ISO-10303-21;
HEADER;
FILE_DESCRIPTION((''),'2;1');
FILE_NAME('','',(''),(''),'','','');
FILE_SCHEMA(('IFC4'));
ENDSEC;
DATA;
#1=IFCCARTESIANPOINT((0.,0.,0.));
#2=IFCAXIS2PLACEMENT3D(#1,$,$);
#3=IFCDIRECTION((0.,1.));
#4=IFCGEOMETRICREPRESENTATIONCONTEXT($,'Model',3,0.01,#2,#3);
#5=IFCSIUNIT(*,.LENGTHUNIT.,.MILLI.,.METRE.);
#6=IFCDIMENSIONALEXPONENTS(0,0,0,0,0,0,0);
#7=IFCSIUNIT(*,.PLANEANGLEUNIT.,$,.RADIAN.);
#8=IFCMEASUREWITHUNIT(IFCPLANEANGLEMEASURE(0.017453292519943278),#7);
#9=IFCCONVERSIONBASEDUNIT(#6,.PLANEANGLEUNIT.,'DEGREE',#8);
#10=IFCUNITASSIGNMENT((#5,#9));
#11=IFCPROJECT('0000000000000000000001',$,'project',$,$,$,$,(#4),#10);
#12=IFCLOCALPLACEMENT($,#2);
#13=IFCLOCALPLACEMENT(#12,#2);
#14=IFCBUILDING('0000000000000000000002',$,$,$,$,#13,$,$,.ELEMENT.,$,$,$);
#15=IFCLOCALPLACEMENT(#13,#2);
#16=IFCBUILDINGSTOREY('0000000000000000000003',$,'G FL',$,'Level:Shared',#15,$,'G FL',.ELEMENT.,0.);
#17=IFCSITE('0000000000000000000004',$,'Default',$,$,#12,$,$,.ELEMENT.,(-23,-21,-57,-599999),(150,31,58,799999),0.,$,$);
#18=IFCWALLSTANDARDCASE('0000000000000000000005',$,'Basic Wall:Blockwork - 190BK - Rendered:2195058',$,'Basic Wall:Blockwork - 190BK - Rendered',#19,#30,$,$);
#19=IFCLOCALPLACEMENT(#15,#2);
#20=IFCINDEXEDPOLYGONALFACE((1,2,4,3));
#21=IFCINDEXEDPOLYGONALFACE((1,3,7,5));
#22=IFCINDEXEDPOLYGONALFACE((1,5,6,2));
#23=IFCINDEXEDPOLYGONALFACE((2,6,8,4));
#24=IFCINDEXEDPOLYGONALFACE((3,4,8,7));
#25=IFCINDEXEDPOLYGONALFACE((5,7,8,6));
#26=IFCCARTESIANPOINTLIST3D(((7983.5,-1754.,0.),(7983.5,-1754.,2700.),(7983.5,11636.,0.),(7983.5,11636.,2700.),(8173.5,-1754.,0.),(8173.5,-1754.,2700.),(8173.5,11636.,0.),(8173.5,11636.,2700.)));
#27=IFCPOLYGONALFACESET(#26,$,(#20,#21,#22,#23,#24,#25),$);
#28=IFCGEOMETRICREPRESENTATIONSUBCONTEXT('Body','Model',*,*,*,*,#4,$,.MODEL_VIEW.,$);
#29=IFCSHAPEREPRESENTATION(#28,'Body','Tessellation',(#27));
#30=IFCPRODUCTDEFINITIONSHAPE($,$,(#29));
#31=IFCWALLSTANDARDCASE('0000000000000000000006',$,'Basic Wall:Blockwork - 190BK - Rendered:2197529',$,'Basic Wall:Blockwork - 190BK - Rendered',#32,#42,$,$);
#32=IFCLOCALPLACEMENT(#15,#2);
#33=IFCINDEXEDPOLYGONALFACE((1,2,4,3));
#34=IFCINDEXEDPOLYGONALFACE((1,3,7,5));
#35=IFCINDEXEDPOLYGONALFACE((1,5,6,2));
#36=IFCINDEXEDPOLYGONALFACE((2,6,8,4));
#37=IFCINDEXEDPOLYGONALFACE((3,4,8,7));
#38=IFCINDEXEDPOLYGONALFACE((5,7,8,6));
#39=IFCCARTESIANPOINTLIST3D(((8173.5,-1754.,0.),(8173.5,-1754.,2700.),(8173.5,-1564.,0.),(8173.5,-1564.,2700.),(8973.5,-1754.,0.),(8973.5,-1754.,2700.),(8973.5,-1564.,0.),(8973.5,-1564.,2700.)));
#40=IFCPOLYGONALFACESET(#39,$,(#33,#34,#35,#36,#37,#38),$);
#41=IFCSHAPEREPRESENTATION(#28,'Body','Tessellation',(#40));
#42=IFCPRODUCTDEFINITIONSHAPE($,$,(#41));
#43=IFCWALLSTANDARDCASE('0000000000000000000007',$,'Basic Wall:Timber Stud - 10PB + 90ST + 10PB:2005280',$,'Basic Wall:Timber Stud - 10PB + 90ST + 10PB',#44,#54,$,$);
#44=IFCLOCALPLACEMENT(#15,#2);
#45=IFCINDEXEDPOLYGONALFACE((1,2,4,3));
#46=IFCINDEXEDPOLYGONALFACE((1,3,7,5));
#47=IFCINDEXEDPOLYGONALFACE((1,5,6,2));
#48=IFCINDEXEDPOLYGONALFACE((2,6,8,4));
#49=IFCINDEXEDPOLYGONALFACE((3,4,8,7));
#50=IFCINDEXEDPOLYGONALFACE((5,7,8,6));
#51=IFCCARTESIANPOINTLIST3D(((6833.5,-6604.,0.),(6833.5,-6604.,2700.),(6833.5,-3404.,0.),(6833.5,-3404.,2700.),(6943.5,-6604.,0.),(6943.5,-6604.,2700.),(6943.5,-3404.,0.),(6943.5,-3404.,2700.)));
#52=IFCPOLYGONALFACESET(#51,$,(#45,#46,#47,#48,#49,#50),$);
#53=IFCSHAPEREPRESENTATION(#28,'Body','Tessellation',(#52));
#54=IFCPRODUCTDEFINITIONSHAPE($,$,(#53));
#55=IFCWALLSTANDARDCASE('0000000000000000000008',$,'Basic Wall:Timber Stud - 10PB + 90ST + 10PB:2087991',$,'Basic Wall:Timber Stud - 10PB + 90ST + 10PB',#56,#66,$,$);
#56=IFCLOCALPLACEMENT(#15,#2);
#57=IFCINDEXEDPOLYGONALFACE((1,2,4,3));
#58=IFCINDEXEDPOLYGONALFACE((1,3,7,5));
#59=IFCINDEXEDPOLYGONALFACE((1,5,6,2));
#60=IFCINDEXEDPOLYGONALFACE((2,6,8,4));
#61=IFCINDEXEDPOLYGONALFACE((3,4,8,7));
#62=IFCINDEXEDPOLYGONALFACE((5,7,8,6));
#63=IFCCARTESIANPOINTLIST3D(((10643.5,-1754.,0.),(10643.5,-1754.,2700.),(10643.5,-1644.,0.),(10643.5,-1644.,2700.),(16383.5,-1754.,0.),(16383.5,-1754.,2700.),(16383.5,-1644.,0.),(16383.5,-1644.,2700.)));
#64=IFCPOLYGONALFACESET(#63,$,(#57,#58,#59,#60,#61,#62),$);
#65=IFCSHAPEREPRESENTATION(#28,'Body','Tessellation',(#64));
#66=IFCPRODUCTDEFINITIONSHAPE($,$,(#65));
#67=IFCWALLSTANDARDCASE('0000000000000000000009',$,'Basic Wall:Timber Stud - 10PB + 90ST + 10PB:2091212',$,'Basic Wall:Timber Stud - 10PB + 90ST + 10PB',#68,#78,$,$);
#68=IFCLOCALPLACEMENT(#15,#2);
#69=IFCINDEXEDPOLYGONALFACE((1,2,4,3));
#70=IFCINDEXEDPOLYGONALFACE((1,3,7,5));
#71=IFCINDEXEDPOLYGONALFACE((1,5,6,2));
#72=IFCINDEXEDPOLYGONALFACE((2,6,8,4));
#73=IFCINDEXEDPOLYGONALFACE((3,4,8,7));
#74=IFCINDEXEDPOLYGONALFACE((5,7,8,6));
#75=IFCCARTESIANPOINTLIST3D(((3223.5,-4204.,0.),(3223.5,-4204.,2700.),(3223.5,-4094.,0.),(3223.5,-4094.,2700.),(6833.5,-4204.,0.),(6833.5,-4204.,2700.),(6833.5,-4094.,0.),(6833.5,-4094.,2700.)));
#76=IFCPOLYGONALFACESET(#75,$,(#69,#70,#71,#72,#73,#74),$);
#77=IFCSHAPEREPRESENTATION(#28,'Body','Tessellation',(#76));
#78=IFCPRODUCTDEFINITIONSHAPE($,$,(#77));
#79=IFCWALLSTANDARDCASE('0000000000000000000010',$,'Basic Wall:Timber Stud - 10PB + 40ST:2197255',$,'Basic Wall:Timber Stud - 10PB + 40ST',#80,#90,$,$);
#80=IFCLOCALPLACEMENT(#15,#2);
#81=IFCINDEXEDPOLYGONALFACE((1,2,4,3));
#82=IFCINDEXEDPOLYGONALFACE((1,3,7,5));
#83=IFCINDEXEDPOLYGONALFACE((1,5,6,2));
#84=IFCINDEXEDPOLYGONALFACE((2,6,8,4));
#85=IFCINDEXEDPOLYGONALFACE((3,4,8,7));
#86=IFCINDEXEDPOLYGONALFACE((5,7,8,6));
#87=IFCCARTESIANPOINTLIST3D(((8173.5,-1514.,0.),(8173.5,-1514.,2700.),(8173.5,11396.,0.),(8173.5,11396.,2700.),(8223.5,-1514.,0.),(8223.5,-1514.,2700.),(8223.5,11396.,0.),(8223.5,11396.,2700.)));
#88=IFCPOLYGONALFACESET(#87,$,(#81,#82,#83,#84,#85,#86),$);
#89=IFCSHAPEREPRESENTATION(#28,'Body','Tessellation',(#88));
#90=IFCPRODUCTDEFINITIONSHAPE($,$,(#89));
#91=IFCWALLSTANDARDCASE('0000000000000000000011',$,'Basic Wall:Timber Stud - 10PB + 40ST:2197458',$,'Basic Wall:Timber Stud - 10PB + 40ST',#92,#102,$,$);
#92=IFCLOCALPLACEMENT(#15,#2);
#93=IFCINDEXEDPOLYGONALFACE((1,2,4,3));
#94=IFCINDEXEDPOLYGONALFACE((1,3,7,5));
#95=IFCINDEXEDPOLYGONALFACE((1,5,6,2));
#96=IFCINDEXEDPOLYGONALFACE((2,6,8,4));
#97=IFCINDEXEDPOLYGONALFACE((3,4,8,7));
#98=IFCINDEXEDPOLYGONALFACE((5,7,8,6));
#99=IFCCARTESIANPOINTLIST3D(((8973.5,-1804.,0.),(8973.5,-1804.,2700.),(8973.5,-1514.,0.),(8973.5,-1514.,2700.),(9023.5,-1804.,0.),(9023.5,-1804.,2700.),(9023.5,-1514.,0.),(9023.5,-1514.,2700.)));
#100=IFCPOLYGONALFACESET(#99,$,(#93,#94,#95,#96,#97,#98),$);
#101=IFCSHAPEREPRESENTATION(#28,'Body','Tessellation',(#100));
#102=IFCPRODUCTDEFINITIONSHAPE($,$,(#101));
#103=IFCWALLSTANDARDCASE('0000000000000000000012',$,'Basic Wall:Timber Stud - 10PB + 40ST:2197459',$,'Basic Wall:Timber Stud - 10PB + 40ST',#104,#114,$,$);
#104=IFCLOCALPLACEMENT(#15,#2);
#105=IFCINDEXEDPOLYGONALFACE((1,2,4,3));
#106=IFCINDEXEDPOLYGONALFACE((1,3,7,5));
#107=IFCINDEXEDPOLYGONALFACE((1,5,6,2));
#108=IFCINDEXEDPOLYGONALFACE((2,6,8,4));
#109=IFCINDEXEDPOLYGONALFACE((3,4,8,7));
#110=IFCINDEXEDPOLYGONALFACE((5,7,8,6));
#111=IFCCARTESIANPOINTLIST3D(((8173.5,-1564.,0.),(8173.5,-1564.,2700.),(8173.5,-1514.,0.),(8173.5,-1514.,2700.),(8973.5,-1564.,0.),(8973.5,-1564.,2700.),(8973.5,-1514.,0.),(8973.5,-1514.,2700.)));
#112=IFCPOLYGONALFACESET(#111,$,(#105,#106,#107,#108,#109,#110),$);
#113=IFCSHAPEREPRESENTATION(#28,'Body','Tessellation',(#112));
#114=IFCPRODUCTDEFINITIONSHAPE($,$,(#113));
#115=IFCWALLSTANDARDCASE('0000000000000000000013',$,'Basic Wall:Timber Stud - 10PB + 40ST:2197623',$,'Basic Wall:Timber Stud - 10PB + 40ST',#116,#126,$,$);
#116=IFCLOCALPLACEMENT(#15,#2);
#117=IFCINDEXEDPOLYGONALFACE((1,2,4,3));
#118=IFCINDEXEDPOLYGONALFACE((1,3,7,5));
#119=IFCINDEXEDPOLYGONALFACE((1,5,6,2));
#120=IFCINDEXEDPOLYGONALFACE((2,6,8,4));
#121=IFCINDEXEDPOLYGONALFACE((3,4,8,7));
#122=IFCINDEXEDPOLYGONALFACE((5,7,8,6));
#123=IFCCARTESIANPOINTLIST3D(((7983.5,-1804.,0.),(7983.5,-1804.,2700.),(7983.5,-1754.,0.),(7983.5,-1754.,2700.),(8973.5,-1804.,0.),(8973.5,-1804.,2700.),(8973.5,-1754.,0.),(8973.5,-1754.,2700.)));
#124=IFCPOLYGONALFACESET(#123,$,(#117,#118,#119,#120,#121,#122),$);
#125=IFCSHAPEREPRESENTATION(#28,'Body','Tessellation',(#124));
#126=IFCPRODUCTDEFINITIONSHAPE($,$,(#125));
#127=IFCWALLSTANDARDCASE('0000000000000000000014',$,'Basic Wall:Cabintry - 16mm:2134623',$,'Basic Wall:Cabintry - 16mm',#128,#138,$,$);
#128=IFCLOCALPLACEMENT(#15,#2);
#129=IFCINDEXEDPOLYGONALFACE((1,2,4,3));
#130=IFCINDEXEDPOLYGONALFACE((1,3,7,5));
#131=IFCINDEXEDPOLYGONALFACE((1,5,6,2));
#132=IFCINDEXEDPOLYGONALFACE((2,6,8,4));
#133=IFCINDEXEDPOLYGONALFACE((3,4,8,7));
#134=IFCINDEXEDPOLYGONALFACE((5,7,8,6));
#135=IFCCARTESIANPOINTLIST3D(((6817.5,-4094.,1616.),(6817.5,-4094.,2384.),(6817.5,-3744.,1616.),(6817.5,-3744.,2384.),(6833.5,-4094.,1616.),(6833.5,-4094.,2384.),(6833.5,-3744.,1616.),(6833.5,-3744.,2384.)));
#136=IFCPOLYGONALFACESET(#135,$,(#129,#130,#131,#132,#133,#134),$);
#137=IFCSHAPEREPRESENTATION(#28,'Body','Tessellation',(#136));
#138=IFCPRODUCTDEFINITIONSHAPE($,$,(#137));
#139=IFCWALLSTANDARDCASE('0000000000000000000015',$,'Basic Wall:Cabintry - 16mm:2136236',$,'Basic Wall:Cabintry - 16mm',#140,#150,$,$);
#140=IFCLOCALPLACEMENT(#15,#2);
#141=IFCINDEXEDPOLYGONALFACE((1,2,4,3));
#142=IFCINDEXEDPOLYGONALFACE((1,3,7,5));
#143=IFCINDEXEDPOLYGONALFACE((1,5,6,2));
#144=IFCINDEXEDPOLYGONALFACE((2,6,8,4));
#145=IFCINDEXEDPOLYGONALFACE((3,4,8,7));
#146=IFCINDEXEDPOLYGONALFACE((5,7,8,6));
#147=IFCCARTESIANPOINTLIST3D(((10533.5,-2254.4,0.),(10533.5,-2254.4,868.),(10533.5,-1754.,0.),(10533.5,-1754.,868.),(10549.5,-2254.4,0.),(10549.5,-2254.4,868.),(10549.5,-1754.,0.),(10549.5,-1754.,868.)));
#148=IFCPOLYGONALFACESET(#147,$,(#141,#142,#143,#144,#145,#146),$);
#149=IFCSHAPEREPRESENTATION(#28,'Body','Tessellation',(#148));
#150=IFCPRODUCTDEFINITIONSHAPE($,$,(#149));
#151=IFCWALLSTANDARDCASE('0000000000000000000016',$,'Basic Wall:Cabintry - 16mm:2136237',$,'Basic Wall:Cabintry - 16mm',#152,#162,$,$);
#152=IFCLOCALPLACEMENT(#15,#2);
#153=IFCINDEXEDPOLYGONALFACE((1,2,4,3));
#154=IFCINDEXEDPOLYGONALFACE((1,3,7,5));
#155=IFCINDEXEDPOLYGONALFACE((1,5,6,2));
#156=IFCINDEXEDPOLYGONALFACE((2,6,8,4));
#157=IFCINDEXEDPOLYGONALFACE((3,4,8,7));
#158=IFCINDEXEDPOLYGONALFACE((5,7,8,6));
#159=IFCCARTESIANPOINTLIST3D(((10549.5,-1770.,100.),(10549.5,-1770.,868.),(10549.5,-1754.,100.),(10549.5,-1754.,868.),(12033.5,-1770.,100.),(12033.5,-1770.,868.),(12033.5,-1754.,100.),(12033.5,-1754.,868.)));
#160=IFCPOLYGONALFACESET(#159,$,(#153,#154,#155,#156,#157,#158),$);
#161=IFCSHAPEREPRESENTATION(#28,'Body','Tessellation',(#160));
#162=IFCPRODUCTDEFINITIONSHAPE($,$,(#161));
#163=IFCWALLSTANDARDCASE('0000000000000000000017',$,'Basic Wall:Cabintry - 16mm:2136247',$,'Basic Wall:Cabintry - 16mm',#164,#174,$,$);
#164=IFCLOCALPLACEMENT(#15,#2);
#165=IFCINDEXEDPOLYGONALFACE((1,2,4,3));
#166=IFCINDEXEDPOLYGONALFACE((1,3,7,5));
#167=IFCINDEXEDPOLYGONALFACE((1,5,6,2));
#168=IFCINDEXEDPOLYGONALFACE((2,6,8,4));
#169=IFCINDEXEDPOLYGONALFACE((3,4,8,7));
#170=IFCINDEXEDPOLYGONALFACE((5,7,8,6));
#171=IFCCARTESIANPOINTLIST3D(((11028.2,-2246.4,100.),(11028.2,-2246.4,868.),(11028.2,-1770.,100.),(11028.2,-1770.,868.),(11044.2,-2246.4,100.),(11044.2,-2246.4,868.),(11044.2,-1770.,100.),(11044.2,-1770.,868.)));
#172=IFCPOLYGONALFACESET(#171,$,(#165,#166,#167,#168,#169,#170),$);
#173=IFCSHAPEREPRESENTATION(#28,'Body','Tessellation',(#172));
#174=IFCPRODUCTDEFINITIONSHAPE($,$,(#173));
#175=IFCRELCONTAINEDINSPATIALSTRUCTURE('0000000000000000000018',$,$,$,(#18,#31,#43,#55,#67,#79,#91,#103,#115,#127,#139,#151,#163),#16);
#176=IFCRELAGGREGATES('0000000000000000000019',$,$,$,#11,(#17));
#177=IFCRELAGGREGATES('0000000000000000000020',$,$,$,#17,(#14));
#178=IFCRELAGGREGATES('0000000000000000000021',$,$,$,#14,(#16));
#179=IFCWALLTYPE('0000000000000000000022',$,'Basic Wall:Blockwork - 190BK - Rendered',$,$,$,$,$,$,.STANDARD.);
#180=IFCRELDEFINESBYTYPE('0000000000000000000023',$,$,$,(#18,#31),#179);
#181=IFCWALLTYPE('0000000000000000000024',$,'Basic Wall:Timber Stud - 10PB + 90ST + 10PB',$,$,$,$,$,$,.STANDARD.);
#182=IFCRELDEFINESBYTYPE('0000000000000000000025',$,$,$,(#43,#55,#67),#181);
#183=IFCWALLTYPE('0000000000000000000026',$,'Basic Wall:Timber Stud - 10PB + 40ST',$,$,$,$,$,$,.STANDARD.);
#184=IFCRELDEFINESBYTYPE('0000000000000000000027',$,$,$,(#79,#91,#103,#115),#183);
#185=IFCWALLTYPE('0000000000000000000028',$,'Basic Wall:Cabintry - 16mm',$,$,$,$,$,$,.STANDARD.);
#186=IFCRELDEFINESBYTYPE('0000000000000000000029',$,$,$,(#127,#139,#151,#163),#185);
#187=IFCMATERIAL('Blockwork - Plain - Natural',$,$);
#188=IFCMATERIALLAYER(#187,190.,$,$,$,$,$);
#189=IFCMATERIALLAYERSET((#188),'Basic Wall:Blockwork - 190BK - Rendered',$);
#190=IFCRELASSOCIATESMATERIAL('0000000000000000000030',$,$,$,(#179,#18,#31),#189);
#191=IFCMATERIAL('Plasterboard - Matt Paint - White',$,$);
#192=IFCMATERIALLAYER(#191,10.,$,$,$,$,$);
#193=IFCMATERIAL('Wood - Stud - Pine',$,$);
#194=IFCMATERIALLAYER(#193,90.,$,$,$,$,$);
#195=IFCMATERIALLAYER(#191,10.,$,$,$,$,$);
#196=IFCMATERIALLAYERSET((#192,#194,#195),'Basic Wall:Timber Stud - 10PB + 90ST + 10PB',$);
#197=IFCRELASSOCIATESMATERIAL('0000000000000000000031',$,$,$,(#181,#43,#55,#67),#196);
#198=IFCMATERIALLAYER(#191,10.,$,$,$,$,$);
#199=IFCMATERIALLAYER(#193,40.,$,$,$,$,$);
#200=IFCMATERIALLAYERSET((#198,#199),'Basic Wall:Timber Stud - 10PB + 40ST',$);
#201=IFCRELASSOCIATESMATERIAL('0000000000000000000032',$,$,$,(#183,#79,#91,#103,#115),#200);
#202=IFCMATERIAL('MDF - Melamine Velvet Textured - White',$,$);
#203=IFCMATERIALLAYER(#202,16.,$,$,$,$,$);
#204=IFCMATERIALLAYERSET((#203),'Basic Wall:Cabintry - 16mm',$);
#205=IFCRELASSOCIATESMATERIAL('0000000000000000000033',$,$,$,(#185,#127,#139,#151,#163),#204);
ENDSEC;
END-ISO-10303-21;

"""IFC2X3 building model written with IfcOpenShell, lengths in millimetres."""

from ifc_helpers import new_model, entity, si_unit, converted_unit, direction, frame, frame_2d, origin, place, context, subcontext, project, spatial, rectangle, extrude, material, layer, layer_set, layer_usage, type_object, element, save


model = new_model("IFC2X3")

# Units and contexts
model_context = context("Model", 3, precision=0.01, world=origin(), true_north=direction((0.0, 1.0)))
body_context = subcontext(model_context, "Body", "Model", "MODEL_VIEW")
ifc_project = project(units=[si_unit("LENGTHUNIT", "METRE", prefix="MILLI"), converted_unit("PLANEANGLEUNIT", "DEGREE", entity("IfcPlaneAngleMeasure", 0.017453292519943278), si_unit("PLANEANGLEUNIT", "RADIAN"), dimensions=[0, 0, 0, 0, 0, 0, 0])], contexts=[model_context])

# Site, building, storey
site_placement = place(None, origin())
site = spatial("IfcSite", under=ifc_project, at=site_placement, Name="Default", CompositionType="ELEMENT", RefLatitude=(-23, -21, -57, -599999), RefLongitude=(150, 31, 58, 799999), RefElevation=0.0)
building_placement = place(site_placement, origin())
building = spatial("IfcBuilding", under=site, at=building_placement, CompositionType="ELEMENT")
storey_placement = place(building_placement, origin())
storey = spatial("IfcBuildingStorey", under=building, at=storey_placement, Name="G FL", ObjectType="Level:Shared", LongName="G FL", CompositionType="ELEMENT", Elevation=0.0)

# Walls
ifc_material_1 = material(Name="Blockwork - Plain - Natural")
ifc_layer_1 = layer(ifc_material_1, 190.0)
ifc_layer_set_1 = layer_set([ifc_layer_1], Name="Basic Wall:Blockwork - 190BK - Rendered")
ifc_layer_usage_1 = layer_usage(ifc_layer_set_1, "AXIS2", "NEGATIVE", 95.0)
wall_type_1 = type_object("IfcWallType", Name="Basic Wall:Blockwork - 190BK - Rendered", PredefinedType="STANDARD", material=ifc_layer_set_1)
wall_1_placement = place(storey_placement, frame((8078.5, -1754.0, 0.0), z_axis=(0.0, 0.0, 1.0), x_axis=(0.0, 1.0, 0.0)))
element("IfcWallStandardCase", 1, at=wall_1_placement, inside=storey, type_object=wall_type_1, material=ifc_layer_usage_1, Name="Basic Wall:Blockwork - 190BK - Rendered:2195058", ObjectType="Basic Wall:Blockwork - 190BK - Rendered", context=body_context, shape_type="SweptSolid", body=[
    extrude(rectangle(XDim=13390.0, YDim=190.0, at=frame_2d((6695.0, 0.0), x_axis=(-1.0, 0.0))), origin(), (0.0, 0.0, 1.0), 2700.0),
])
ifc_layer_usage_2 = layer_usage(ifc_layer_set_1, "AXIS2", "POSITIVE", -95.0)
wall_2_placement = place(storey_placement, frame((8973.5, -1659.0, 0.0), z_axis=(0.0, 0.0, 1.0), x_axis=(-1.0, 0.0, 0.0)))
element("IfcWallStandardCase", 2, at=wall_2_placement, inside=storey, type_object=wall_type_1, material=ifc_layer_usage_2, Name="Basic Wall:Blockwork - 190BK - Rendered:2197529", ObjectType="Basic Wall:Blockwork - 190BK - Rendered", context=body_context, shape_type="SweptSolid", body=[
    extrude(rectangle(XDim=800.0, YDim=190.0, at=frame_2d((400.0, 0.0), x_axis=(-1.0, 0.0))), origin(), (0.0, 0.0, 1.0), 2700.0),
])
ifc_material_2 = material(Name="Plasterboard - Matt Paint - White")
ifc_layer_2 = layer(ifc_material_2, 10.0)
ifc_material_3 = material(Name="Wood - Stud - Pine")
ifc_layer_3 = layer(ifc_material_3, 90.0)
ifc_layer_4 = layer(ifc_material_2, 10.0)
ifc_layer_set_2 = layer_set([ifc_layer_2, ifc_layer_3, ifc_layer_4], Name="Basic Wall:Timber Stud - 10PB + 90ST + 10PB")
ifc_layer_usage_3 = layer_usage(ifc_layer_set_2, "AXIS2", "NEGATIVE", 55.0)
wall_type_2 = type_object("IfcWallType", Name="Basic Wall:Timber Stud - 10PB + 90ST + 10PB", PredefinedType="STANDARD", material=ifc_layer_set_2)
wall_3_placement = place(storey_placement, frame((6888.5, -3404.0, 0.0), z_axis=(0.0, 0.0, 1.0), x_axis=(0.0, -1.0, 0.0)))
element("IfcWallStandardCase", 3, at=wall_3_placement, inside=storey, type_object=wall_type_2, material=ifc_layer_usage_3, Name="Basic Wall:Timber Stud - 10PB + 90ST + 10PB:2005280", ObjectType="Basic Wall:Timber Stud - 10PB + 90ST + 10PB", context=body_context, shape_type="SweptSolid", body=[
    extrude(rectangle(XDim=3200.0, YDim=110.0, at=frame_2d((1600.0, 0.0), x_axis=(-1.0, 0.0))), origin(), (0.0, 0.0, 1.0), 2700.0),
])
ifc_layer_usage_4 = layer_usage(ifc_layer_set_2, "AXIS2", "NEGATIVE", 55.0)
wall_4_placement = place(storey_placement, frame((10643.5, -1699.0, 0.0)))
element("IfcWallStandardCase", 4, at=wall_4_placement, inside=storey, type_object=wall_type_2, material=ifc_layer_usage_4, Name="Basic Wall:Timber Stud - 10PB + 90ST + 10PB:2087991", ObjectType="Basic Wall:Timber Stud - 10PB + 90ST + 10PB", context=body_context, shape_type="SweptSolid", body=[
    extrude(rectangle(XDim=5740.0, YDim=110.0, at=frame_2d((2870.0, 0.0), x_axis=(-1.0, 0.0))), origin(), (0.0, 0.0, 1.0), 2700.0),
])
ifc_layer_usage_5 = layer_usage(ifc_layer_set_2, "AXIS2", "POSITIVE", -55.0)
wall_5_placement = place(storey_placement, frame((6833.5, -4149.0, 0.0), z_axis=(0.0, 0.0, 1.0), x_axis=(-1.0, 0.0, 0.0)))
element("IfcWallStandardCase", 5, at=wall_5_placement, inside=storey, type_object=wall_type_2, material=ifc_layer_usage_5, Name="Basic Wall:Timber Stud - 10PB + 90ST + 10PB:2091212", ObjectType="Basic Wall:Timber Stud - 10PB + 90ST + 10PB", context=body_context, shape_type="SweptSolid", body=[
    extrude(rectangle(XDim=3610.0, YDim=110.0, at=frame_2d((1805.0, 0.0), x_axis=(-1.0, 0.0))), origin(), (0.0, 0.0, 1.0), 2700.0),
])
ifc_layer_5 = layer(ifc_material_2, 10.0)
ifc_layer_6 = layer(ifc_material_3, 40.0)
ifc_layer_set_3 = layer_set([ifc_layer_5, ifc_layer_6], Name="Basic Wall:Timber Stud - 10PB + 40ST")
ifc_layer_usage_6 = layer_usage(ifc_layer_set_3, "AXIS2", "POSITIVE", -25.0)
wall_type_3 = type_object("IfcWallType", Name="Basic Wall:Timber Stud - 10PB + 40ST", PredefinedType="STANDARD", material=ifc_layer_set_3)
wall_6_placement = place(storey_placement, frame((8198.5, -1514.0, 0.0), z_axis=(0.0, 0.0, 1.0), x_axis=(0.0, 1.0, 0.0)))
element("IfcWallStandardCase", 6, at=wall_6_placement, inside=storey, type_object=wall_type_3, material=ifc_layer_usage_6, Name="Basic Wall:Timber Stud - 10PB + 40ST:2197255", ObjectType="Basic Wall:Timber Stud - 10PB + 40ST", context=body_context, shape_type="SweptSolid", body=[
    extrude(rectangle(XDim=12910.0, YDim=50.0, at=frame_2d((6455.0, 0.0), x_axis=(-1.0, 0.0))), origin(), (0.0, 0.0, 1.0), 2700.0),
])
ifc_layer_usage_7 = layer_usage(ifc_layer_set_3, "AXIS2", "POSITIVE", -25.0)
wall_7_placement = place(storey_placement, frame((8998.5, -1804.0, 0.0), z_axis=(0.0, 0.0, 1.0), x_axis=(0.0, 1.0, 0.0)))
element("IfcWallStandardCase", 7, at=wall_7_placement, inside=storey, type_object=wall_type_3, material=ifc_layer_usage_7, Name="Basic Wall:Timber Stud - 10PB + 40ST:2197458", ObjectType="Basic Wall:Timber Stud - 10PB + 40ST", context=body_context, shape_type="SweptSolid", body=[
    extrude(rectangle(XDim=290.0, YDim=50.0, at=frame_2d((145.0, 0.0), x_axis=(-1.0, 0.0))), origin(), (0.0, 0.0, 1.0), 2700.0),
])
ifc_layer_usage_8 = layer_usage(ifc_layer_set_3, "AXIS2", "POSITIVE", -25.0)
wall_8_placement = place(storey_placement, frame((8973.5, -1539.0, 0.0), z_axis=(0.0, 0.0, 1.0), x_axis=(-1.0, 0.0, 0.0)))
element("IfcWallStandardCase", 8, at=wall_8_placement, inside=storey, type_object=wall_type_3, material=ifc_layer_usage_8, Name="Basic Wall:Timber Stud - 10PB + 40ST:2197459", ObjectType="Basic Wall:Timber Stud - 10PB + 40ST", context=body_context, shape_type="SweptSolid", body=[
    extrude(rectangle(XDim=800.0, YDim=50.0, at=frame_2d((400.0, 0.0), x_axis=(-1.0, 0.0))), origin(), (0.0, 0.0, 1.0), 2700.0),
])
ifc_layer_usage_9 = layer_usage(ifc_layer_set_3, "AXIS2", "NEGATIVE", 25.0)
wall_9_placement = place(storey_placement, frame((8973.5, -1779.0, 0.0), z_axis=(0.0, 0.0, 1.0), x_axis=(-1.0, 0.0, 0.0)))
element("IfcWallStandardCase", 9, at=wall_9_placement, inside=storey, type_object=wall_type_3, material=ifc_layer_usage_9, Name="Basic Wall:Timber Stud - 10PB + 40ST:2197623", ObjectType="Basic Wall:Timber Stud - 10PB + 40ST", context=body_context, shape_type="SweptSolid", body=[
    extrude(rectangle(XDim=990.0, YDim=50.0, at=frame_2d((495.0, 0.0), x_axis=(-1.0, 0.0))), origin(), (0.0, 0.0, 1.0), 2700.0),
])
ifc_material_4 = material(Name="MDF - Melamine Velvet Textured - White")
ifc_layer_7 = layer(ifc_material_4, 16.0)
ifc_layer_set_4 = layer_set([ifc_layer_7], Name="Basic Wall:Cabintry - 16mm")
ifc_layer_usage_10 = layer_usage(ifc_layer_set_4, "AXIS2", "NEGATIVE", 8.0)
wall_type_4 = type_object("IfcWallType", Name="Basic Wall:Cabintry - 16mm", PredefinedType="STANDARD", material=ifc_layer_set_4)
wall_10_placement = place(storey_placement, frame((6825.5, -3744.0, 1616.0), z_axis=(0.0, 0.0, 1.0), x_axis=(0.0, -1.0, 0.0)))
element("IfcWallStandardCase", 10, at=wall_10_placement, inside=storey, type_object=wall_type_4, material=ifc_layer_usage_10, Name="Basic Wall:Cabintry - 16mm:2134623", ObjectType="Basic Wall:Cabintry - 16mm", context=body_context, shape_type="SweptSolid", body=[
    extrude(rectangle(XDim=350.0, YDim=16.0, at=frame_2d((175.0, 0.0), x_axis=(-1.0, 0.0))), origin(), (0.0, 0.0, 1.0), 768.0),
])
ifc_layer_usage_11 = layer_usage(ifc_layer_set_4, "AXIS2", "NEGATIVE", 8.0)
wall_11_placement = place(storey_placement, frame((10541.5, -1754.0, 0.0), z_axis=(0.0, 0.0, 1.0), x_axis=(0.0, -1.0, 0.0)))
element("IfcWallStandardCase", 11, at=wall_11_placement, inside=storey, type_object=wall_type_4, material=ifc_layer_usage_11, Name="Basic Wall:Cabintry - 16mm:2136236", ObjectType="Basic Wall:Cabintry - 16mm", context=body_context, shape_type="SweptSolid", body=[
    extrude(rectangle(XDim=500.4, YDim=16.0, at=frame_2d((250.2, 0.0), x_axis=(-1.0, 0.0))), origin(), (0.0, 0.0, 1.0), 868.0),
])
ifc_layer_usage_12 = layer_usage(ifc_layer_set_4, "AXIS2", "POSITIVE", -8.0)
wall_12_placement = place(storey_placement, frame((10549.5, -1762.0, 100.0)))
element("IfcWallStandardCase", 12, at=wall_12_placement, inside=storey, type_object=wall_type_4, material=ifc_layer_usage_12, Name="Basic Wall:Cabintry - 16mm:2136237", ObjectType="Basic Wall:Cabintry - 16mm", context=body_context, shape_type="SweptSolid", body=[
    extrude(rectangle(XDim=1484.0, YDim=16.0, at=frame_2d((742.0, 0.0), x_axis=(-1.0, 0.0))), origin(), (0.0, 0.0, 1.0), 768.0),
])
ifc_layer_usage_13 = layer_usage(ifc_layer_set_4, "AXIS2", "NEGATIVE", 8.0)
wall_13_placement = place(storey_placement, frame((11036.2, -2246.4, 100.0), z_axis=(0.0, 0.0, 1.0), x_axis=(0.0, 1.0, 0.0)))
element("IfcWallStandardCase", 13, at=wall_13_placement, inside=storey, type_object=wall_type_4, material=ifc_layer_usage_13, Name="Basic Wall:Cabintry - 16mm:2136247", ObjectType="Basic Wall:Cabintry - 16mm", context=body_context, shape_type="SweptSolid", body=[
    extrude(rectangle(XDim=476.4, YDim=16.0, at=frame_2d((238.2, 0.0), x_axis=(-1.0, 0.0))), origin(), (0.0, 0.0, 1.0), 768.0),
])

save(model, "model.ifc")
